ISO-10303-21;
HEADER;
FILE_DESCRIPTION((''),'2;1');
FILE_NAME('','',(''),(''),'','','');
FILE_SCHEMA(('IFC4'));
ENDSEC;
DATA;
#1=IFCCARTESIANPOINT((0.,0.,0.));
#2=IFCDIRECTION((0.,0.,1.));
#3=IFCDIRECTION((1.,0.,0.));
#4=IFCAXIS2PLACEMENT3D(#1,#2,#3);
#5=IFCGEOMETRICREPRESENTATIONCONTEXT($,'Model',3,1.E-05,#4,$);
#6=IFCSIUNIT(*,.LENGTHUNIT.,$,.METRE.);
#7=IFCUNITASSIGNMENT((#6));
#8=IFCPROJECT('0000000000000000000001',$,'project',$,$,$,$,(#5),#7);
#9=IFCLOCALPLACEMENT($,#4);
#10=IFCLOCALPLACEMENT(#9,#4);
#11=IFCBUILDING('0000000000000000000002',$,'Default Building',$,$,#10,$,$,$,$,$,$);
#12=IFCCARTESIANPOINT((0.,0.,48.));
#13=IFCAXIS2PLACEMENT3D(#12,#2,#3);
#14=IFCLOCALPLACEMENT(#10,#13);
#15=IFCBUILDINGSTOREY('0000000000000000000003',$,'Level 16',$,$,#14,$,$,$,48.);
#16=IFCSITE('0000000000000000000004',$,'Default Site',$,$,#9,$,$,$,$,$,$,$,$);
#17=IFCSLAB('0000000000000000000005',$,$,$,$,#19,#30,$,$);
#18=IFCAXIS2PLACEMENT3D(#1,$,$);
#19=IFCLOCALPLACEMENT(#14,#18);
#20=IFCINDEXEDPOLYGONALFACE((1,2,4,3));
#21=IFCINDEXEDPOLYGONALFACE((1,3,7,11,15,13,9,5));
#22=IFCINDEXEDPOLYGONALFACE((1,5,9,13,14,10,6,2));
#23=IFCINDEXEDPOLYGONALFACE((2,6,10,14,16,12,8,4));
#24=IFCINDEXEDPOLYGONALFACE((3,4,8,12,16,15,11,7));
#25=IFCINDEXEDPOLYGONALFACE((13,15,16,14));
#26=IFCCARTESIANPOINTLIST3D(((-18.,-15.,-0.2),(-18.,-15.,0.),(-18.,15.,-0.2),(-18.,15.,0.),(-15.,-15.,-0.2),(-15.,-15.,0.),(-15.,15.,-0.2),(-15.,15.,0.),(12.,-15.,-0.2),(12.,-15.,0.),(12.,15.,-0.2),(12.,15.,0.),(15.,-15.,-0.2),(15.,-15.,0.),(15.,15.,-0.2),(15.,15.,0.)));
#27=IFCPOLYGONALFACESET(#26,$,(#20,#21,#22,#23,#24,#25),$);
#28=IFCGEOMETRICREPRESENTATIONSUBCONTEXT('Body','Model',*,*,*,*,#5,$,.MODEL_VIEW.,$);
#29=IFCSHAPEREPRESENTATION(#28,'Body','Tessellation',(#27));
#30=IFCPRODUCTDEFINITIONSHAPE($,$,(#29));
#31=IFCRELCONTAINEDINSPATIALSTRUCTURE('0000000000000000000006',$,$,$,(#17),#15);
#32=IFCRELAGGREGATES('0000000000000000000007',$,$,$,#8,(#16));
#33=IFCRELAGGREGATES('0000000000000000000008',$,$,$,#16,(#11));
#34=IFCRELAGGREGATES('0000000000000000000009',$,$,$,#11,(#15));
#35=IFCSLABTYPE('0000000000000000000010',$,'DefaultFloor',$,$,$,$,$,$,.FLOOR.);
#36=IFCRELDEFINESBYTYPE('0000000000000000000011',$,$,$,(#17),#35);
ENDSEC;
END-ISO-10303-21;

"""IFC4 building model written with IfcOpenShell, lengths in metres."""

from ifc_helpers import new_model, si_unit, frame, origin_with_axes, place, context, subcontext, project, spatial, polyline, outline, extrude, type_object, element, save


model = new_model("IFC4")

# Units and contexts
model_context = context("Model", 3, precision=1e-05, world=origin_with_axes())
body_context = subcontext(model_context, "Body", "Model", "MODEL_VIEW")
ifc_project = project(units=[si_unit("LENGTHUNIT", "METRE")], contexts=[model_context])

# Site, building, storey
site_placement = place(None, origin_with_axes())
site = spatial("IfcSite", under=ifc_project, at=site_placement, Name="Default Site")
building_placement = place(site_placement, origin_with_axes())
building = spatial("IfcBuilding", under=site, at=building_placement, Name="Default Building")
storey_placement = place(building_placement, frame((0.0, 0.0, 48.0), z_axis=(0.0, 0.0, 1.0), x_axis=(1.0, 0.0, 0.0)))
storey = spatial("IfcBuildingStorey", under=building, at=storey_placement, Name="Level 16", Elevation=48.0)

# Slab
slab_type = type_object("IfcSlabType", Name="DefaultFloor", PredefinedType="FLOOR")
slab_placement = place(storey_placement, frame((0.0, 0.0, -48.0), z_axis=(0.0, 0.0, 1.0), x_axis=(1.0, 0.0, 0.0)))
element("IfcSlab", 1, at=slab_placement, inside=storey, type_object=slab_type, context=body_context, shape_type="SweptSolid", body=[
    extrude(outline(polyline([(-18.0, 15.0), (-15.0, 15.0), (12.0, 15.0), (15.0, 15.0), (15.0, -15.0), (12.0, -15.0), (-15.0, -15.0), (-18.0, -15.0), (-18.0, 15.0)])), frame((0.0, 0.0, 48.0), z_axis=(0.0, 0.0, 1.0), x_axis=(1.0, 0.0, 0.0)), (0.0, 0.0, -1.0), 0.2),
])

save(model, "model.ifc")
